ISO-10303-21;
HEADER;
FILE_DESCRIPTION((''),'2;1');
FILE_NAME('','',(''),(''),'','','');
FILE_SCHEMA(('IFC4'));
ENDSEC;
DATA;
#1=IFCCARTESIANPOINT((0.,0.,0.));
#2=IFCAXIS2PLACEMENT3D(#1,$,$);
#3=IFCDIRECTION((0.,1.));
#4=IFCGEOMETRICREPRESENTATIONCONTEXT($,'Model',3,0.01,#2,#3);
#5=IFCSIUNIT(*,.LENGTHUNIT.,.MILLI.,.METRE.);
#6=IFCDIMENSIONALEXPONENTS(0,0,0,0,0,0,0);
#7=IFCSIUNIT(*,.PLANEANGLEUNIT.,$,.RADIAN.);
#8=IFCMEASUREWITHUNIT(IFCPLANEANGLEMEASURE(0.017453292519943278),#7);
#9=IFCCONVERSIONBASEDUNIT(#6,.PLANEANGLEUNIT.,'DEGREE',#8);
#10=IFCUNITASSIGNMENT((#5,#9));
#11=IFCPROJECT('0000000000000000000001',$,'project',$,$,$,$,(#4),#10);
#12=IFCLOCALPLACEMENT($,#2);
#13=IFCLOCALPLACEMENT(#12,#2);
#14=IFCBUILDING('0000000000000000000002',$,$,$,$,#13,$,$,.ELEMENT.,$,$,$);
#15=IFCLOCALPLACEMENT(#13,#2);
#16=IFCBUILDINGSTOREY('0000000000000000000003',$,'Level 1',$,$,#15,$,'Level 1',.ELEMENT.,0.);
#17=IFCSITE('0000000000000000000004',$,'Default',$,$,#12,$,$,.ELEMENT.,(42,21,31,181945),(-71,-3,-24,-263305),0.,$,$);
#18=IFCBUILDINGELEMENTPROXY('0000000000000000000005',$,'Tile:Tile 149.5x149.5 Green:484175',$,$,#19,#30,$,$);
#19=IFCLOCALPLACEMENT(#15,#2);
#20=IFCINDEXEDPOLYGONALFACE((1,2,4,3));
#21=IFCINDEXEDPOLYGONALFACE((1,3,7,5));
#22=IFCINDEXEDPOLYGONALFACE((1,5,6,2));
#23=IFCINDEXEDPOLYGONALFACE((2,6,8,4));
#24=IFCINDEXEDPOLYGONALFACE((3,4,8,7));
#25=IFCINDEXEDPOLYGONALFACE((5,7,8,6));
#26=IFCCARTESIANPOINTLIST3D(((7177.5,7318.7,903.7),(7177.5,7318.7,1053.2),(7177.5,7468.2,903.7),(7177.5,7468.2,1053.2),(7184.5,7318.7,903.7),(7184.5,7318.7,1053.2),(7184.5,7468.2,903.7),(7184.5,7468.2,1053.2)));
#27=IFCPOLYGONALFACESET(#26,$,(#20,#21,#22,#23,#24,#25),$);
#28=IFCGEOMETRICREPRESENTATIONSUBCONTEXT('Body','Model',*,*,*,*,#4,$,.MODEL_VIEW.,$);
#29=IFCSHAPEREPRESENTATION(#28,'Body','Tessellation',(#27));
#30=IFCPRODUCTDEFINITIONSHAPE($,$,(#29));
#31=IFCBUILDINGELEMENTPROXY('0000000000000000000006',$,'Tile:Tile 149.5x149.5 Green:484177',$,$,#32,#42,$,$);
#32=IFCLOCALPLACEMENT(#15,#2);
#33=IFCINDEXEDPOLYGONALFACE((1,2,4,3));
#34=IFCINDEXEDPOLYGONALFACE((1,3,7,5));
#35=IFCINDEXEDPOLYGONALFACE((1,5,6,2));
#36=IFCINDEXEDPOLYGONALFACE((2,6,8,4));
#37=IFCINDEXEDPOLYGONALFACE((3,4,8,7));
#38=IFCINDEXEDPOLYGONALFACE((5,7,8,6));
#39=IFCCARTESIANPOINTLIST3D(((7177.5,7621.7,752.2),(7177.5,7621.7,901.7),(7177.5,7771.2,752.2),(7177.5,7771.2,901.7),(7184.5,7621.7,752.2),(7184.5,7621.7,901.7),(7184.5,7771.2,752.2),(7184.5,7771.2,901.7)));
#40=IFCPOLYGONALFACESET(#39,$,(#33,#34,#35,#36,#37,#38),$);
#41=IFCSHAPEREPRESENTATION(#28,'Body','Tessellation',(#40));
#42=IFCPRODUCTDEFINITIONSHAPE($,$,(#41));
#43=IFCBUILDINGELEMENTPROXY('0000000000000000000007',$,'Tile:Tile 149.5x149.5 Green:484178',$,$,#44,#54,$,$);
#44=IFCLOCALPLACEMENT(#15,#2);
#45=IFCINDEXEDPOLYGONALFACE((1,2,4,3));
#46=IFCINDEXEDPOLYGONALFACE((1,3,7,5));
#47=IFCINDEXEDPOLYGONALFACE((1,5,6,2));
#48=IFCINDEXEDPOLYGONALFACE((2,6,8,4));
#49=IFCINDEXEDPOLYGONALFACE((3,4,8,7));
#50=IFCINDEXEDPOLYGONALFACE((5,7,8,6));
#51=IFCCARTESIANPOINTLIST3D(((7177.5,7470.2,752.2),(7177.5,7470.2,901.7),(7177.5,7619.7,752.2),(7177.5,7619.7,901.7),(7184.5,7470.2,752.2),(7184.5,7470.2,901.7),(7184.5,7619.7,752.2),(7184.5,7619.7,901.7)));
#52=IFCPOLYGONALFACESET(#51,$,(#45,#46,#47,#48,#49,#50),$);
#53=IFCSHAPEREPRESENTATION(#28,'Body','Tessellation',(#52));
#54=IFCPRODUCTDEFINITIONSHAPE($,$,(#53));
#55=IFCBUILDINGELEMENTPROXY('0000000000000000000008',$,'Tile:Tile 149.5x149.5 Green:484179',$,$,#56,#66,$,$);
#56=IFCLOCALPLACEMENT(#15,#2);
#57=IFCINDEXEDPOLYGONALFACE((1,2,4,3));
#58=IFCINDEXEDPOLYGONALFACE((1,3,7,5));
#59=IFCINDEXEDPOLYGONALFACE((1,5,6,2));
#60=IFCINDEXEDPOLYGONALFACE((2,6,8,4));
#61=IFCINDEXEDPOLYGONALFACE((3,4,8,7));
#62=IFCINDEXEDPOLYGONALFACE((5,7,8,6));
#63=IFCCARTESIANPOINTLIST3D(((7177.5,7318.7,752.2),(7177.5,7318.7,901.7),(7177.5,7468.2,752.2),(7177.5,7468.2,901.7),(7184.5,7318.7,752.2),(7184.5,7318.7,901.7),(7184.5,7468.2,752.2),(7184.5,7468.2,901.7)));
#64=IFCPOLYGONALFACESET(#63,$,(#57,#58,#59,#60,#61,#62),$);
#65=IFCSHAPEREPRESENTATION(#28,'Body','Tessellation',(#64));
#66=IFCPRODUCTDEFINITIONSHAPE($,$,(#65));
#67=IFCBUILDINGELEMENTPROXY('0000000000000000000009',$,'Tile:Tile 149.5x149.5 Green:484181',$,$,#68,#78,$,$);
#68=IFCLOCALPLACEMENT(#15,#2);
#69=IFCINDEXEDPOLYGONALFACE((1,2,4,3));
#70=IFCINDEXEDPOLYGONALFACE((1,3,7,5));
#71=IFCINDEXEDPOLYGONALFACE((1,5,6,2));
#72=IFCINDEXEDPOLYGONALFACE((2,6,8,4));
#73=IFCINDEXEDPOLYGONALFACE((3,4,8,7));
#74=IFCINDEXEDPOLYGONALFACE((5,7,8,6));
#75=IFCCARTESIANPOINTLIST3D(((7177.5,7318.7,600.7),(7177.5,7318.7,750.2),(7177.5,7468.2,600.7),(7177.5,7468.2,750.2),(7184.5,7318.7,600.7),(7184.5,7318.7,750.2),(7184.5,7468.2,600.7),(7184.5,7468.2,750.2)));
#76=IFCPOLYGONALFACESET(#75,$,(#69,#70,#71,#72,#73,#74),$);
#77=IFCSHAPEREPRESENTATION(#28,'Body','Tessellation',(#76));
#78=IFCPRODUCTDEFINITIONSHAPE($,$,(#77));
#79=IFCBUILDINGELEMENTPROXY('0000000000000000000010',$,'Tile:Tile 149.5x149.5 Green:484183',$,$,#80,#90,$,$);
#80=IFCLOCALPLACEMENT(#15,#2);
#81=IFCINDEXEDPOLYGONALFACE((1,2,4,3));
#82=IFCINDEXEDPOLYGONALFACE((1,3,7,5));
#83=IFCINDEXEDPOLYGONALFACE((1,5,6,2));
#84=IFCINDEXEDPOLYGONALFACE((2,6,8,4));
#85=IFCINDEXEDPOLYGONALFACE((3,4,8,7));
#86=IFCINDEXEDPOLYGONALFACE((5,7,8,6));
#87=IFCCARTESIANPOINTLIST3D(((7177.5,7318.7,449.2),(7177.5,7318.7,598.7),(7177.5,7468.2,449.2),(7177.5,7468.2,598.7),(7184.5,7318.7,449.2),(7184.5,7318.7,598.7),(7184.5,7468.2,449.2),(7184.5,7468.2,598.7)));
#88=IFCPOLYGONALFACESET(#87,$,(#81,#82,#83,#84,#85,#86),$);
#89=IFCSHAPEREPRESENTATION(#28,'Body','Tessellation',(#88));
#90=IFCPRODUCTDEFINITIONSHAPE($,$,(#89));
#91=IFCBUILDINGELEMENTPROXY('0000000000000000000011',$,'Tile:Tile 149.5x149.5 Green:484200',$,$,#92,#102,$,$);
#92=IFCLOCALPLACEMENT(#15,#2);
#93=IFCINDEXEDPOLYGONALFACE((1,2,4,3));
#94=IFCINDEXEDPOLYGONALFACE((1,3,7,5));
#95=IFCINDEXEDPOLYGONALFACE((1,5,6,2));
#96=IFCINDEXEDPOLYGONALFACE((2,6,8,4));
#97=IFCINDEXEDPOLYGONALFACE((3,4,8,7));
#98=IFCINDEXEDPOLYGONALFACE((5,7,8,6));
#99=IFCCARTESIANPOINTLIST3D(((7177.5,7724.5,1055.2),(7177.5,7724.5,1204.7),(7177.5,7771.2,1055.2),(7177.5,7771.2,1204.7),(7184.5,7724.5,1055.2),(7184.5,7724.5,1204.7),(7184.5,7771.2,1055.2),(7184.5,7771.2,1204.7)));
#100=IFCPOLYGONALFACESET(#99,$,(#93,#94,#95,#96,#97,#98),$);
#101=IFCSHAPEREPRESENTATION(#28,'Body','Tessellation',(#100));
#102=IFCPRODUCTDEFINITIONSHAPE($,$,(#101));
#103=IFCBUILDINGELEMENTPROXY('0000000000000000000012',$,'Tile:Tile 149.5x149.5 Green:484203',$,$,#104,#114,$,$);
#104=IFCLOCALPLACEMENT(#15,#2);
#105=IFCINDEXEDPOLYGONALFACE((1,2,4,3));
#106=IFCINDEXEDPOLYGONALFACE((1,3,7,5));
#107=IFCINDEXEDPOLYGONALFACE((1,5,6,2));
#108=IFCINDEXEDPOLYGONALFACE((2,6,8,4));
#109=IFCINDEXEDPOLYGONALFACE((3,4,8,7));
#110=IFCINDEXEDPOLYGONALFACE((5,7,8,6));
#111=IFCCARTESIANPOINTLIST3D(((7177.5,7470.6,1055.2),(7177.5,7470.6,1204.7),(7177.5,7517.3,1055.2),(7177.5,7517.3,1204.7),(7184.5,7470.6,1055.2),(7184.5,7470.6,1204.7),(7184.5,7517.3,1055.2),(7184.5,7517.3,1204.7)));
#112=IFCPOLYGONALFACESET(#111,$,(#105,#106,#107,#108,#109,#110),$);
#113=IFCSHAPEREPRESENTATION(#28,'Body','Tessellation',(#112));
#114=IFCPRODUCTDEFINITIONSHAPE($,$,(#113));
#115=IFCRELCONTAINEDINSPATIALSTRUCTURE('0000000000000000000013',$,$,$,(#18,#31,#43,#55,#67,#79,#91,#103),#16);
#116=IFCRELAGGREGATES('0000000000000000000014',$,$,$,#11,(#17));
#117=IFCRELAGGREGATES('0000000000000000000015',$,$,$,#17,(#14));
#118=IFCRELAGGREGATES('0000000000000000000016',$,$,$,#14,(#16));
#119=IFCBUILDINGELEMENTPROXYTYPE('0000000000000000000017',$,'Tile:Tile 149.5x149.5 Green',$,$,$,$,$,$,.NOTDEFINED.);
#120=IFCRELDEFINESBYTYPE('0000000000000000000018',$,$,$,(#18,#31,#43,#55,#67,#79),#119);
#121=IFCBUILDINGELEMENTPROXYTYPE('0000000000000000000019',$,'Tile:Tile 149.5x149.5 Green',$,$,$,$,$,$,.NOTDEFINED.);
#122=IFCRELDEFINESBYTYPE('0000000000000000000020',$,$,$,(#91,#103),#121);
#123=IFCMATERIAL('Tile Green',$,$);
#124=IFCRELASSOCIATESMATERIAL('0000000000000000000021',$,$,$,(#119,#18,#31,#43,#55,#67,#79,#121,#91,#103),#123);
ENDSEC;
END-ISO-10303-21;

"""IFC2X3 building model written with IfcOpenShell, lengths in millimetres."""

from ifc_helpers import new_model, entity, si_unit, converted_unit, direction, frame, origin, origin_2d_with_axis, place, context, subcontext, project, spatial, rectangle, extrude, source, transform, mapped, material, type_object, type_shapes, element, save


model = new_model("IFC2X3")

# Units and contexts
model_context = context("Model", 3, precision=0.01, world=origin(), true_north=direction((0.0, 1.0)))
body_context = subcontext(model_context, "Body", "Model", "MODEL_VIEW")
ifc_project = project(units=[si_unit("LENGTHUNIT", "METRE", prefix="MILLI"), converted_unit("PLANEANGLEUNIT", "DEGREE", entity("IfcPlaneAngleMeasure", 0.017453292519943278), si_unit("PLANEANGLEUNIT", "RADIAN"), dimensions=[0, 0, 0, 0, 0, 0, 0])], contexts=[model_context])

# Site, building, storey
site_placement = place(None, origin())
site = spatial("IfcSite", under=ifc_project, at=site_placement, Name="Default", CompositionType="ELEMENT", RefLatitude=(42, 21, 31, 181945), RefLongitude=(-71, -3, -24, -263305), RefElevation=0.0)
building_placement = place(site_placement, origin())
building = spatial("IfcBuilding", under=site, at=building_placement, CompositionType="ELEMENT")
storey_placement = place(building_placement, origin())
storey = spatial("IfcBuildingStorey", under=building, at=storey_placement, Name="Level 1", LongName="Level 1", CompositionType="ELEMENT", Elevation=0.0)

# Building element proxies
ifc_material_1 = material(Name="Tile Green")
building_element_proxy_type_1 = type_object("IfcBuildingElementProxyType", Name="Tile:Tile 149.5x149.5 Green", PredefinedType="NOTDEFINED", material=ifc_material_1)
shared_shape_1 = source(origin(), body_context, "Body", "SweptSolid", [
    extrude(rectangle(XDim=149.5, YDim=149.5, at=origin_2d_with_axis()), frame((-74.7, -74.8, 0.0), z_axis=(0.0, 0.0, 1.0), x_axis=(0.0, -1.0, 0.0)), (0.0, 0.0, 1.0), 7.0),
])
type_shapes(building_element_proxy_type_1, [shared_shape_1])
for number, where, z_axis, x_axis, name in (
    (1, (7184.5, 7468.2, 1053.2), (-1.0, 0.0, 0.0), (0.0, 0.0, 1.0), "Tile:Tile 149.5x149.5 Green:484175"),
    (2, (7184.5, 7771.2, 901.7), (-1.0, 0.0, 0.0), (0.0, 0.0, 1.0), "Tile:Tile 149.5x149.5 Green:484177"),
    (3, (7184.5, 7619.7, 901.7), (-1.0, 0.0, 0.0), (0.0, 0.0, 1.0), "Tile:Tile 149.5x149.5 Green:484178"),
    (4, (7184.5, 7468.2, 901.7), (-1.0, 0.0, 0.0), (0.0, 0.0, 1.0), "Tile:Tile 149.5x149.5 Green:484179"),
    (5, (7184.5, 7468.2, 750.2), (-1.0, 0.0, 0.0), (0.0, 0.0, 1.0), "Tile:Tile 149.5x149.5 Green:484181"),
    (6, (7184.5, 7468.2, 598.7), (-1.0, 0.0, 0.0), (0.0, 0.0, 1.0), "Tile:Tile 149.5x149.5 Green:484183"),
):
    element("IfcBuildingElementProxy", number, at=place(storey_placement, frame(where, z_axis=z_axis, x_axis=x_axis)), inside=storey, type_object=building_element_proxy_type_1, material=ifc_material_1, Name=name, context=body_context, shape_type="MappedRepresentation", body=[
        mapped(shared_shape_1, transform((0.0, 0.0, 0.0), scale=1.0)),
    ])
building_element_proxy_type_2 = type_object("IfcBuildingElementProxyType", Name="Tile:Tile 149.5x149.5 Green", PredefinedType="NOTDEFINED", material=ifc_material_1)
shared_shape_2 = source(origin(), body_context, "Body", "SweptSolid", [
    extrude(rectangle(XDim=46.7, YDim=149.5, at=origin_2d_with_axis()), frame((-23.3, -74.8, 0.0), z_axis=(0.0, 0.0, 1.0), x_axis=(-1.0, 0.0, 0.0)), (0.0, 0.0, 1.0), 7.0),
])
type_shapes(building_element_proxy_type_2, [shared_shape_2])
for number, where, z_axis, x_axis, name in (
    (7, (7184.5, 7771.2, 1055.2), (-1.0, 0.0, 0.0), (0.0, 1.0, 0.0), "Tile:Tile 149.5x149.5 Green:484200"),
    (8, (7184.5, 7517.3, 1055.2), (-1.0, 0.0, 0.0), (0.0, 1.0, 0.0), "Tile:Tile 149.5x149.5 Green:484203"),
):
    element("IfcBuildingElementProxy", number, at=place(storey_placement, frame(where, z_axis=z_axis, x_axis=x_axis)), inside=storey, type_object=building_element_proxy_type_2, material=ifc_material_1, Name=name, context=body_context, shape_type="MappedRepresentation", body=[
        mapped(shared_shape_2, transform((0.0, 0.0, 0.0), scale=1.0)),
    ])

save(model, "model.ifc")
